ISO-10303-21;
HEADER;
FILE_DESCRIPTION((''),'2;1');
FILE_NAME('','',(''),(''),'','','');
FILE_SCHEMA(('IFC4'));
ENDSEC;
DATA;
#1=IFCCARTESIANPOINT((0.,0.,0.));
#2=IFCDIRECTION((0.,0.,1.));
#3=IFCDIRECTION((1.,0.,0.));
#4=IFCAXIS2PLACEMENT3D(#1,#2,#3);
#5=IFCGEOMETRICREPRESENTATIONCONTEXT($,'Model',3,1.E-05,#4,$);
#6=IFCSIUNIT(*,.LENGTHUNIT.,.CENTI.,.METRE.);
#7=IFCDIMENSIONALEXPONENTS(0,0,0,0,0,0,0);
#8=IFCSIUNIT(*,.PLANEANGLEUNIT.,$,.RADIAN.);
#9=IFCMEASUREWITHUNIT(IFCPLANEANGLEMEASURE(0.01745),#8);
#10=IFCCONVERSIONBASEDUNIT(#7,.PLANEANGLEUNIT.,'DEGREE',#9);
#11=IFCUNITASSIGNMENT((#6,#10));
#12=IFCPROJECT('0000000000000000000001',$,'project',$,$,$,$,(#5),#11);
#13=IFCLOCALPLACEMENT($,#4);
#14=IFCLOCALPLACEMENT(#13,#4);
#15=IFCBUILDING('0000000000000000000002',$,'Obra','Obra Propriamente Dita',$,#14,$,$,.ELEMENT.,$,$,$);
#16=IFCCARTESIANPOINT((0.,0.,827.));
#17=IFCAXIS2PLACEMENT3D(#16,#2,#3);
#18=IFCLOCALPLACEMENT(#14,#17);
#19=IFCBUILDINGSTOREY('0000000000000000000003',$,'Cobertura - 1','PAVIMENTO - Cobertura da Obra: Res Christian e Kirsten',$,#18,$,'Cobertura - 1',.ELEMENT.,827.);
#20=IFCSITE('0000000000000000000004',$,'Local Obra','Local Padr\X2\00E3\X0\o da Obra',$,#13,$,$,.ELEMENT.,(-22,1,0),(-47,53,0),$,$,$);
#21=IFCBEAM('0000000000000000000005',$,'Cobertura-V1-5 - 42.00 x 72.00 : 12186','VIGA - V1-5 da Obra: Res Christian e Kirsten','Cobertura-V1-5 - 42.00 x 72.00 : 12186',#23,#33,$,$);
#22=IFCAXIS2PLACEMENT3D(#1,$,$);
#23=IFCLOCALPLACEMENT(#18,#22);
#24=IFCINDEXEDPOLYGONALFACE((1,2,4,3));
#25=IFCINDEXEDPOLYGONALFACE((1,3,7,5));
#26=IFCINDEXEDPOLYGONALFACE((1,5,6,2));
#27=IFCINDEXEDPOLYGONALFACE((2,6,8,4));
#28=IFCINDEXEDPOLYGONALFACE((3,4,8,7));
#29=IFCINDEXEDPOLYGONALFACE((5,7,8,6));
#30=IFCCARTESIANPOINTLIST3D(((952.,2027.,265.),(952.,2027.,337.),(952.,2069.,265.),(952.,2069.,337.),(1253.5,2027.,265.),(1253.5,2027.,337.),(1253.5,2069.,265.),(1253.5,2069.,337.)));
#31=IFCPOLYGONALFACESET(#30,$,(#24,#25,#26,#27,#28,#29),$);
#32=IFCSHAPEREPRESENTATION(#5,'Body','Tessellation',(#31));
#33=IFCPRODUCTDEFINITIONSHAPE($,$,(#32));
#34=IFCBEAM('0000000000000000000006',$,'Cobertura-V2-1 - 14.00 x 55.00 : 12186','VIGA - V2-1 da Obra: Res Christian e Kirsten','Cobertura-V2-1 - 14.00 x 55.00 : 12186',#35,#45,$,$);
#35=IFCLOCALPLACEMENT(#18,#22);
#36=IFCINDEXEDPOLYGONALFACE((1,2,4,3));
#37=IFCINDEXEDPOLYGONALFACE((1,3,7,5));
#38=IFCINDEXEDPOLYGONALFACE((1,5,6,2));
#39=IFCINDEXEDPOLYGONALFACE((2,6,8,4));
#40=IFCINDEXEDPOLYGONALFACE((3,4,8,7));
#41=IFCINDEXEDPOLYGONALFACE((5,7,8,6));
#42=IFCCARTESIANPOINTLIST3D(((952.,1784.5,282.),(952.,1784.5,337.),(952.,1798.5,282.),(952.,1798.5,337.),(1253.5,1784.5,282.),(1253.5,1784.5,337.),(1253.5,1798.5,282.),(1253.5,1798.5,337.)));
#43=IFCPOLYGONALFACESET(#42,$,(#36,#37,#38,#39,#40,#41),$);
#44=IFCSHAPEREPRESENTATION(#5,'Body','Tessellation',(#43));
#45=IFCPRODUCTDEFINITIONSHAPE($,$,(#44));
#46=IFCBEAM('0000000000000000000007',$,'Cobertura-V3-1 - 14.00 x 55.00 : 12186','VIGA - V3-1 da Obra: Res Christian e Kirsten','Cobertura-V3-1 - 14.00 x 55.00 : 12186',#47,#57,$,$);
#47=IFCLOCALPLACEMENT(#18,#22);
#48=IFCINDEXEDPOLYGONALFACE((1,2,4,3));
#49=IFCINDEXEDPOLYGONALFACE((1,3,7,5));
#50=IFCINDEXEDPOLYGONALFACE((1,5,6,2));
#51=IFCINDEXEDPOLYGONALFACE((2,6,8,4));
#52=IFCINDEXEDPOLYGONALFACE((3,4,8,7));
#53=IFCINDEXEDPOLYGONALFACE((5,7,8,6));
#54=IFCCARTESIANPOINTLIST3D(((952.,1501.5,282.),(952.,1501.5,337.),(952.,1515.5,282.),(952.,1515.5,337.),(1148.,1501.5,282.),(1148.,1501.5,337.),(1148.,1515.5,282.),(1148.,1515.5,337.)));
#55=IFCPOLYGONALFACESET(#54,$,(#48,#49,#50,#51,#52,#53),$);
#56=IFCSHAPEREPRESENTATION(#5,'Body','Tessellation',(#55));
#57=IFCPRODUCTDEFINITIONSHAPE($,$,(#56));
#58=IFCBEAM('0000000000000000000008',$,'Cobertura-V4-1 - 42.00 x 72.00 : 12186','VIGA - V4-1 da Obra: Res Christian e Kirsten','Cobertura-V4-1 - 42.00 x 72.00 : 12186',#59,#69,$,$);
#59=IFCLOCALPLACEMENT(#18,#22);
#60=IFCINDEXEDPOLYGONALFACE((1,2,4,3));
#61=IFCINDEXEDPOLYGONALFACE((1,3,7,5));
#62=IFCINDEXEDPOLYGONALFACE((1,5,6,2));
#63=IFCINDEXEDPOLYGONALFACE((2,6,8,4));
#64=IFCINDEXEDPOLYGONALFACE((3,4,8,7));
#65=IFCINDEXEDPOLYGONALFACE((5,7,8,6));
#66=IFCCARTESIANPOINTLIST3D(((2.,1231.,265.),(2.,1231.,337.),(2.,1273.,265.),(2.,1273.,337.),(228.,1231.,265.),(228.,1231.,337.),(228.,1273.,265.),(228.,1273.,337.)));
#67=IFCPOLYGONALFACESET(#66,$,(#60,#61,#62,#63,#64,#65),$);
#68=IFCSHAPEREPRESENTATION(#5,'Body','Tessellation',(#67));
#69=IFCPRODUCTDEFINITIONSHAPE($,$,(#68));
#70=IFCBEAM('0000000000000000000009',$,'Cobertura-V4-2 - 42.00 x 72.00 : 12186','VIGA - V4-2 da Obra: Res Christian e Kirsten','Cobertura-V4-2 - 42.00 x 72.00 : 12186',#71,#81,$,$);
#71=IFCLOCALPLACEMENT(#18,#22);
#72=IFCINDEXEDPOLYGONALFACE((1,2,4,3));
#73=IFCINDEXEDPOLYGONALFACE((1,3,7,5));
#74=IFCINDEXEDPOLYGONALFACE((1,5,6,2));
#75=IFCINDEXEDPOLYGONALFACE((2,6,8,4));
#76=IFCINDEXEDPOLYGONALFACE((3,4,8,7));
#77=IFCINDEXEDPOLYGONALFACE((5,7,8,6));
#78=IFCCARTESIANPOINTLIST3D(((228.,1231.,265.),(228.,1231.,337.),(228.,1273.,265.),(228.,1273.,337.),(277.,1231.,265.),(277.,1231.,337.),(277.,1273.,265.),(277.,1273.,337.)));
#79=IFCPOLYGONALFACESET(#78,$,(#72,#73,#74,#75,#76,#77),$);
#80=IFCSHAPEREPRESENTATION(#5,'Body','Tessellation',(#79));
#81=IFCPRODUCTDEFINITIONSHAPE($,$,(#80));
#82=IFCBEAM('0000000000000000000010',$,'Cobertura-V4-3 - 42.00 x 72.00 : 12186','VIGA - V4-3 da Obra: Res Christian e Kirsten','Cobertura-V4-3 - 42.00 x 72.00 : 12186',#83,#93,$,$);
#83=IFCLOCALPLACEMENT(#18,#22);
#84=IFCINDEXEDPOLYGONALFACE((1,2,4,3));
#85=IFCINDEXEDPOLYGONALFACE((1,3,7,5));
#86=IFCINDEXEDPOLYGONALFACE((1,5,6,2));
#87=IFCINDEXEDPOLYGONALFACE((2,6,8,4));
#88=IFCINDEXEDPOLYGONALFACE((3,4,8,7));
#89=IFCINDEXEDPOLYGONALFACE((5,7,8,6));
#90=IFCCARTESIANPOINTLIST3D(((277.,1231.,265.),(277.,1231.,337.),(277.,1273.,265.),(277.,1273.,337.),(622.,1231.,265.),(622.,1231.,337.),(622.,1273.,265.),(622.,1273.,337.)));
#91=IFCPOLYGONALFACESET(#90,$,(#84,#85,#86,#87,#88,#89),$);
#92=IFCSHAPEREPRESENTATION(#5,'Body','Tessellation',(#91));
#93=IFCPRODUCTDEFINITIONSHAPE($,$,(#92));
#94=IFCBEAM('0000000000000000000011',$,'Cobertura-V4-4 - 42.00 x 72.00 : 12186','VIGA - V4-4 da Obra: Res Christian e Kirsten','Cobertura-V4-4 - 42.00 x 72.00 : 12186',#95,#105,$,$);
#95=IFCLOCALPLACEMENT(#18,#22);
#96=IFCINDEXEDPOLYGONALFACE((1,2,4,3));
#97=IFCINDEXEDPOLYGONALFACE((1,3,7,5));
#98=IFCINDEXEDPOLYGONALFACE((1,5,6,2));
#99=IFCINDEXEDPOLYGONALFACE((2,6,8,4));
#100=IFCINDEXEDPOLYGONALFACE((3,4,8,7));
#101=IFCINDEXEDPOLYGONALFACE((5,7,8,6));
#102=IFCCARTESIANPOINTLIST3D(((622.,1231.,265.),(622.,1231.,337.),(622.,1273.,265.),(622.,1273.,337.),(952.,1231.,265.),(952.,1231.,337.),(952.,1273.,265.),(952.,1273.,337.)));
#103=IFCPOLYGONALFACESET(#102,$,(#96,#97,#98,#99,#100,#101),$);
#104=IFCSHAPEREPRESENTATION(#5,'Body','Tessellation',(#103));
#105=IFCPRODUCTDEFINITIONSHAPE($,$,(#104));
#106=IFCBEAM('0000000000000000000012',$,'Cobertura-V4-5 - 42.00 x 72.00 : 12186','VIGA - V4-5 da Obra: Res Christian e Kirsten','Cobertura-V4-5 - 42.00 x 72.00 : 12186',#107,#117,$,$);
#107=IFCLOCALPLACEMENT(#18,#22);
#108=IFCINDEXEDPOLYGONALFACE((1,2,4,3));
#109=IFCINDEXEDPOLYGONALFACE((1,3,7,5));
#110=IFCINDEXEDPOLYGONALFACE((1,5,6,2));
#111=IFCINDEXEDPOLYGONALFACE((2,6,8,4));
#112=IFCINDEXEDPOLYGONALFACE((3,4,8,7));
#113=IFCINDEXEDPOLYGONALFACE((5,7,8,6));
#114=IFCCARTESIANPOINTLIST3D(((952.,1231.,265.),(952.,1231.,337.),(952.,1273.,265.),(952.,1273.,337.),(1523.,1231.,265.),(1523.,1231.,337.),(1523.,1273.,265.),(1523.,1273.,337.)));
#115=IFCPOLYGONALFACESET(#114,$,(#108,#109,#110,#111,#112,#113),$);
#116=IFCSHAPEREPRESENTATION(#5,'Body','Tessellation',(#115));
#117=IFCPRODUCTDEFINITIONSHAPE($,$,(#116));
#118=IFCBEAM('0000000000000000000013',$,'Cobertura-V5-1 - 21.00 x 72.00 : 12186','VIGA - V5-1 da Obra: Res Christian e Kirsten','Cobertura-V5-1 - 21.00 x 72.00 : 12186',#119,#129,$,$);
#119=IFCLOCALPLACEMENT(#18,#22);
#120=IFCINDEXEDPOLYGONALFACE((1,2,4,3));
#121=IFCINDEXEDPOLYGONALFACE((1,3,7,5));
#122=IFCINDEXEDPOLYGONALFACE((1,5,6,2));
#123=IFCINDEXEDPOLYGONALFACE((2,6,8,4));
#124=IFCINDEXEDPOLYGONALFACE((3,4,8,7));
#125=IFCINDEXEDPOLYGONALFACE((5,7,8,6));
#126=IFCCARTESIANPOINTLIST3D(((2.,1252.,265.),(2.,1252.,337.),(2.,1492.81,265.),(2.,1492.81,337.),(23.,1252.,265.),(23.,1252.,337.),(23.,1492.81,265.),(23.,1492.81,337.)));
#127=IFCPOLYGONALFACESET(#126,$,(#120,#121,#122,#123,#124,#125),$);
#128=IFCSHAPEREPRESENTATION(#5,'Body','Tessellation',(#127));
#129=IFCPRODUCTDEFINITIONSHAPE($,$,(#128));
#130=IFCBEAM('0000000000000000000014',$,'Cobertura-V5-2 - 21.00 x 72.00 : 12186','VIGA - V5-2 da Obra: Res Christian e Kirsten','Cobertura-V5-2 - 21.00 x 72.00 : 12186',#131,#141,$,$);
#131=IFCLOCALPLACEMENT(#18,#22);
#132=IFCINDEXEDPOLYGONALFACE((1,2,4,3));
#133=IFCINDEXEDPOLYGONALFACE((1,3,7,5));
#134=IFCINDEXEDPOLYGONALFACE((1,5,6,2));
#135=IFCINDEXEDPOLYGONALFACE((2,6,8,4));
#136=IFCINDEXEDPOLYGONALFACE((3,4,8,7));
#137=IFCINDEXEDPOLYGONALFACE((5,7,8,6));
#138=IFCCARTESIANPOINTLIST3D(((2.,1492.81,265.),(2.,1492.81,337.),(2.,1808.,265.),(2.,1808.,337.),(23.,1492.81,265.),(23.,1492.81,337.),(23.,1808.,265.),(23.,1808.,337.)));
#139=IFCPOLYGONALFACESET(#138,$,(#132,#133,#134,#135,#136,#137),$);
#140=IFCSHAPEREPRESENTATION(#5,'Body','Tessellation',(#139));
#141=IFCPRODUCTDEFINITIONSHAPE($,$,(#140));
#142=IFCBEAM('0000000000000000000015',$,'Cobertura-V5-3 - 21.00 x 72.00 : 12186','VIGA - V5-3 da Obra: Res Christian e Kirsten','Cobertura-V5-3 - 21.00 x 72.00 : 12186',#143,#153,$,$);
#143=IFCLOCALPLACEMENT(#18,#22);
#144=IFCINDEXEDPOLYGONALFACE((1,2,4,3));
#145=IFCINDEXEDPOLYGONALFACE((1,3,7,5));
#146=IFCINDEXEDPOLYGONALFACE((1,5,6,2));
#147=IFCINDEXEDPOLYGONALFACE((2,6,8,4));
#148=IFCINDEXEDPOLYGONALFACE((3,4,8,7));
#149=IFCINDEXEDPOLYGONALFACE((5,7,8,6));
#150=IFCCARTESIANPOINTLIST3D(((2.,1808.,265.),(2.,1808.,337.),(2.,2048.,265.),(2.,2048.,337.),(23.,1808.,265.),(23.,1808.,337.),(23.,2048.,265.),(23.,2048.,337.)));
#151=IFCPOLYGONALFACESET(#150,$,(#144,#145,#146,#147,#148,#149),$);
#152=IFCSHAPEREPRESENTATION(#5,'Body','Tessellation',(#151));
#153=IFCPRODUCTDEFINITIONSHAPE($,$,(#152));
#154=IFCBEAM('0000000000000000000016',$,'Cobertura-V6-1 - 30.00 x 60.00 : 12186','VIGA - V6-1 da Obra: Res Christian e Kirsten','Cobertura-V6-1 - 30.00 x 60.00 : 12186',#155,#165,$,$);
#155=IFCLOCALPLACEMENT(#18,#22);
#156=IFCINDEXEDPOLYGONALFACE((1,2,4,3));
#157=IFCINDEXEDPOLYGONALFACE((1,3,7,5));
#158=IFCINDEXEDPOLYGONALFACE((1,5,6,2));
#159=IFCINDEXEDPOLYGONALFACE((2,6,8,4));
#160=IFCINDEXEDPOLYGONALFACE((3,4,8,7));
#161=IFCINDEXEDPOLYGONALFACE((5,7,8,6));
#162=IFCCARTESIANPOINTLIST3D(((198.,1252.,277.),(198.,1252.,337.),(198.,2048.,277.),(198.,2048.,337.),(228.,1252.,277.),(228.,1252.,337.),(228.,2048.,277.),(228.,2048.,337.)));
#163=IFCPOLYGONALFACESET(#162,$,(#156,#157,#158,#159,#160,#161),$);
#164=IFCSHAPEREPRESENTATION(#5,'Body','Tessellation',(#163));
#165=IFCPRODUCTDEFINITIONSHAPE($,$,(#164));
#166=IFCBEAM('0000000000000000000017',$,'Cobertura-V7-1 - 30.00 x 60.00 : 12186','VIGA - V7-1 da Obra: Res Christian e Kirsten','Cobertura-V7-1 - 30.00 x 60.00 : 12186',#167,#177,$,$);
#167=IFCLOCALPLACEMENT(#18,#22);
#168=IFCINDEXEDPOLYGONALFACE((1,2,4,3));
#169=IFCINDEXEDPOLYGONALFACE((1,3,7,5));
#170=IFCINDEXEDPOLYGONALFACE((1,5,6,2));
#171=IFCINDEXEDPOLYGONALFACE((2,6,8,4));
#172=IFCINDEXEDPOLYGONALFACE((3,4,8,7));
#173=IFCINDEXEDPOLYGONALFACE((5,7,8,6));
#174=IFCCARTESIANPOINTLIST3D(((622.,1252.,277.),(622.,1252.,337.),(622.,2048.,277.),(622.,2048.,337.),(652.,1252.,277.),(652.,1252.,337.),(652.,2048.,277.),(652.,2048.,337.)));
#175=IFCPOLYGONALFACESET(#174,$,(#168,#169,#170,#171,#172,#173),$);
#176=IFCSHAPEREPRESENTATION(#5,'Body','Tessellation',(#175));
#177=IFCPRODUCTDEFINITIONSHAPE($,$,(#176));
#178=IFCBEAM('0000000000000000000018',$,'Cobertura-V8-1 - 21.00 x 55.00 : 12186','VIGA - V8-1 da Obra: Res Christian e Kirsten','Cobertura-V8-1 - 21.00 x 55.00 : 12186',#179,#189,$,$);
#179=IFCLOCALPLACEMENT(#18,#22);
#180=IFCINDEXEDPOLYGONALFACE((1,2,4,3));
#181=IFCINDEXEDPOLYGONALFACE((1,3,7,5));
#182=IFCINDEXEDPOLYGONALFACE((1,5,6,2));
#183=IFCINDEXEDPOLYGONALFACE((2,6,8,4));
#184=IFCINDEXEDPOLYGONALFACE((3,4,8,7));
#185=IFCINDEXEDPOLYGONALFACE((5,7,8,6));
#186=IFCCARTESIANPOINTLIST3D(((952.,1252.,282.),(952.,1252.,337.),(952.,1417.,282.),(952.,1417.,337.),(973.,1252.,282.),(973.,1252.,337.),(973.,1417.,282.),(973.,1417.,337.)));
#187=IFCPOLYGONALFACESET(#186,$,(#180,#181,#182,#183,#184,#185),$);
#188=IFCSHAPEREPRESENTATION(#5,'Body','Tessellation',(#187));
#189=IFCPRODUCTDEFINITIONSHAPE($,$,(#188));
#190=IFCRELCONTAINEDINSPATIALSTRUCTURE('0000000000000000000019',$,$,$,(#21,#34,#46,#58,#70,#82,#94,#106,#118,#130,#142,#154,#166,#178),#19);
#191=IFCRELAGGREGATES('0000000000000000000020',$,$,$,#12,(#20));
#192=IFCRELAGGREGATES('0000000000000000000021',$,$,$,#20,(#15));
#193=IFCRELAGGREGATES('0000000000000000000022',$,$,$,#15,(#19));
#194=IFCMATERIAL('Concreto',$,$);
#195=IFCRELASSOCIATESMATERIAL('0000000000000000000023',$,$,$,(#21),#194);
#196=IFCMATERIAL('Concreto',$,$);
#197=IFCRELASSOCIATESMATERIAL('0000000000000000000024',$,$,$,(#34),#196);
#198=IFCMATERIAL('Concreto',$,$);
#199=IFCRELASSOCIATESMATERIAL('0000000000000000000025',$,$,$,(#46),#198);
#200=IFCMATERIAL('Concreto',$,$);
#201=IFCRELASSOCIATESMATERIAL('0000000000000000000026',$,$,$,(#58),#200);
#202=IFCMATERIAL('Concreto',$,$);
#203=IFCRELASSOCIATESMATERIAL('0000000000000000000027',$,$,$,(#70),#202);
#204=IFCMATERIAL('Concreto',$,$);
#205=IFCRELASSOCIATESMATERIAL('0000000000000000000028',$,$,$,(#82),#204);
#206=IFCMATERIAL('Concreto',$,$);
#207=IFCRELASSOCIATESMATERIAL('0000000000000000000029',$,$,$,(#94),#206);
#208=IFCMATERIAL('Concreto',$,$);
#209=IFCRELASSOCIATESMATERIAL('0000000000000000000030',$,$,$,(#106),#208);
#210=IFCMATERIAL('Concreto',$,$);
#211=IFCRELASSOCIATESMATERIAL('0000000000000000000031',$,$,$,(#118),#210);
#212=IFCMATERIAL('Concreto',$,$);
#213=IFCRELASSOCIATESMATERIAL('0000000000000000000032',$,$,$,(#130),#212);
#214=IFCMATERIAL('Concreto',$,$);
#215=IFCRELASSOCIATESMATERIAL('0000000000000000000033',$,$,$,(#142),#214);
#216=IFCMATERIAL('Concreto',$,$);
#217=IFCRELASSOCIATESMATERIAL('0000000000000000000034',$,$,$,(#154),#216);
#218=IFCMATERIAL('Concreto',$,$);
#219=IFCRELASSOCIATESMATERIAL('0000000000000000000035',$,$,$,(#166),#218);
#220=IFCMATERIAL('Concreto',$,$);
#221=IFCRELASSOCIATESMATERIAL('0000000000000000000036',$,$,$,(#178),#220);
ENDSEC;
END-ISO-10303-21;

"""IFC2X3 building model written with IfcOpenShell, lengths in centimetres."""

from ifc_helpers import new_model, entity, si_unit, converted_unit, frame, origin_with_axes, place, context, project, spatial, polyline, outline, extrude, material, element, save


model = new_model("IFC2X3")

# Units and contexts
model_context = context("Model", 3, precision=1e-05, world=origin_with_axes())
ifc_project = project(units=[si_unit("LENGTHUNIT", "METRE", prefix="CENTI"), converted_unit("PLANEANGLEUNIT", "DEGREE", entity("IfcPlaneAngleMeasure", 0.01745), si_unit("PLANEANGLEUNIT", "RADIAN"), dimensions=[0, 0, 0, 0, 0, 0, 0])], contexts=[model_context])

# Site, building, storey
site_placement = place(None, origin_with_axes())
site = spatial("IfcSite", under=ifc_project, at=site_placement, Name="Local Obra", Description="Local Padrão da Obra", CompositionType="ELEMENT", RefLatitude=(-22, 1, 0), RefLongitude=(-47, 53, 0))
building_placement = place(site_placement, origin_with_axes())
building = spatial("IfcBuilding", under=site, at=building_placement, Name="Obra", Description="Obra Propriamente Dita", CompositionType="ELEMENT")
storey_placement = place(building_placement, frame((0.0, 0.0, 827.0), z_axis=(0.0, 0.0, 1.0), x_axis=(1.0, 0.0, 0.0)))
storey = spatial("IfcBuildingStorey", under=building, at=storey_placement, Name="Cobertura - 1", Description="PAVIMENTO - Cobertura da Obra: Res Christian e Kirsten", LongName="Cobertura - 1", CompositionType="ELEMENT", Elevation=827.0)

# Beams
ifc_material_1 = material(Name="Concreto")
beam_1_placement = place(storey_placement, frame((952.0, 2048.0, 337.0), z_axis=(1.0, 0.0, 0.0), x_axis=(0.0, -1.0, 0.0)))
element("IfcBeam", 1, at=beam_1_placement, inside=storey, material=ifc_material_1, Name="Cobertura-V1-5 - 42.00 x 72.00 : 12186", Description="VIGA - V1-5 da Obra: Res Christian e Kirsten", ObjectType="Cobertura-V1-5 - 42.00 x 72.00 : 12186", context=model_context, shape_type="SweptSolid", body=[
    extrude(outline(polyline([(-21.0, 0.0), (21.0, 0.0), (21.0, 72.0), (-21.0, 72.0), (-21.0, 0.0)])), origin_with_axes(), (0.0, 0.0, 1.0), 301.5),
])
ifc_material_2 = material(Name="Concreto")
beam_2_placement = place(storey_placement, frame((952.0, 1791.5, 337.0), z_axis=(1.0, 0.0, 0.0), x_axis=(0.0, -1.0, 0.0)))
element("IfcBeam", 2, at=beam_2_placement, inside=storey, material=ifc_material_2, Name="Cobertura-V2-1 - 14.00 x 55.00 : 12186", Description="VIGA - V2-1 da Obra: Res Christian e Kirsten", ObjectType="Cobertura-V2-1 - 14.00 x 55.00 : 12186", context=model_context, shape_type="SweptSolid", body=[
    extrude(outline(polyline([(-7.0, 0.0), (7.0, 0.0), (7.0, 55.0), (-7.0, 55.0), (-7.0, 0.0)])), origin_with_axes(), (0.0, 0.0, 1.0), 301.5),
])
ifc_material_3 = material(Name="Concreto")
beam_3_placement = place(storey_placement, frame((952.0, 1508.5, 337.0), z_axis=(1.0, 0.0, 0.0), x_axis=(0.0, -1.0, 0.0)))
element("IfcBeam", 3, at=beam_3_placement, inside=storey, material=ifc_material_3, Name="Cobertura-V3-1 - 14.00 x 55.00 : 12186", Description="VIGA - V3-1 da Obra: Res Christian e Kirsten", ObjectType="Cobertura-V3-1 - 14.00 x 55.00 : 12186", context=model_context, shape_type="SweptSolid", body=[
    extrude(outline(polyline([(-7.0, 0.0), (7.0, 0.0), (7.0, 55.0), (-7.0, 55.0), (-7.0, 0.0)])), origin_with_axes(), (0.0, 0.0, 1.0), 196.0),
])
ifc_material_4 = material(Name="Concreto")
beam_4_placement = place(storey_placement, frame((2.0, 1252.0, 337.0), z_axis=(1.0, 0.0, 0.0), x_axis=(0.0, -1.0, 0.0)))
element("IfcBeam", 4, at=beam_4_placement, inside=storey, material=ifc_material_4, Name="Cobertura-V4-1 - 42.00 x 72.00 : 12186", Description="VIGA - V4-1 da Obra: Res Christian e Kirsten", ObjectType="Cobertura-V4-1 - 42.00 x 72.00 : 12186", context=model_context, shape_type="SweptSolid", body=[
    extrude(outline(polyline([(-21.0, 0.0), (21.0, 0.0), (21.0, 72.0), (-21.0, 72.0), (-21.0, 0.0)])), origin_with_axes(), (0.0, 0.0, 1.0), 226.0),
])
ifc_material_5 = material(Name="Concreto")
beam_5_placement = place(storey_placement, frame((228.0, 1252.0, 337.0), z_axis=(1.0, 0.0, 0.0), x_axis=(0.0, -1.0, 0.0)))
element("IfcBeam", 5, at=beam_5_placement, inside=storey, material=ifc_material_5, Name="Cobertura-V4-2 - 42.00 x 72.00 : 12186", Description="VIGA - V4-2 da Obra: Res Christian e Kirsten", ObjectType="Cobertura-V4-2 - 42.00 x 72.00 : 12186", context=model_context, shape_type="SweptSolid", body=[
    extrude(outline(polyline([(-21.0, 0.0), (21.0, 0.0), (21.0, 72.0), (-21.0, 72.0), (-21.0, 0.0)])), origin_with_axes(), (0.0, 0.0, 1.0), 49.0),
])
ifc_material_6 = material(Name="Concreto")
beam_6_placement = place(storey_placement, frame((277.0, 1252.0, 337.0), z_axis=(1.0, 0.0, 0.0), x_axis=(0.0, -1.0, 0.0)))
element("IfcBeam", 6, at=beam_6_placement, inside=storey, material=ifc_material_6, Name="Cobertura-V4-3 - 42.00 x 72.00 : 12186", Description="VIGA - V4-3 da Obra: Res Christian e Kirsten", ObjectType="Cobertura-V4-3 - 42.00 x 72.00 : 12186", context=model_context, shape_type="SweptSolid", body=[
    extrude(outline(polyline([(-21.0, 0.0), (21.0, 0.0), (21.0, 72.0), (-21.0, 72.0), (-21.0, 0.0)])), origin_with_axes(), (0.0, 0.0, 1.0), 345.0),
])
ifc_material_7 = material(Name="Concreto")
beam_7_placement = place(storey_placement, frame((622.0, 1252.0, 337.0), z_axis=(1.0, 0.0, 0.0), x_axis=(0.0, -1.0, 0.0)))
element("IfcBeam", 7, at=beam_7_placement, inside=storey, material=ifc_material_7, Name="Cobertura-V4-4 - 42.00 x 72.00 : 12186", Description="VIGA - V4-4 da Obra: Res Christian e Kirsten", ObjectType="Cobertura-V4-4 - 42.00 x 72.00 : 12186", context=model_context, shape_type="SweptSolid", body=[
    extrude(outline(polyline([(-21.0, 0.0), (21.0, 0.0), (21.0, 72.0), (-21.0, 72.0), (-21.0, 0.0)])), origin_with_axes(), (0.0, 0.0, 1.0), 330.0),
])
ifc_material_8 = material(Name="Concreto")
beam_8_placement = place(storey_placement, frame((952.0, 1252.0, 337.0), z_axis=(1.0, 0.0, 0.0), x_axis=(0.0, -1.0, 0.0)))
element("IfcBeam", 8, at=beam_8_placement, inside=storey, material=ifc_material_8, Name="Cobertura-V4-5 - 42.00 x 72.00 : 12186", Description="VIGA - V4-5 da Obra: Res Christian e Kirsten", ObjectType="Cobertura-V4-5 - 42.00 x 72.00 : 12186", context=model_context, shape_type="SweptSolid", body=[
    extrude(outline(polyline([(-21.0, 0.0), (21.0, 0.0), (21.0, 72.0), (-21.0, 72.0), (-21.0, 0.0)])), origin_with_axes(), (0.0, 0.0, 1.0), 571.0),
])
ifc_material_9 = material(Name="Concreto")
beam_9_placement = place(storey_placement, frame((2.0, 1252.0, 337.0), z_axis=(-0.000002, 1.0, 0.0), x_axis=(1.0, 0.000002, 0.0)))
element("IfcBeam", 9, at=beam_9_placement, inside=storey, material=ifc_material_9, Name="Cobertura-V5-1 - 21.00 x 72.00 : 12186", Description="VIGA - V5-1 da Obra: Res Christian e Kirsten", ObjectType="Cobertura-V5-1 - 21.00 x 72.00 : 12186", context=model_context, shape_type="SweptSolid", body=[
    extrude(outline(polyline([(0.0, 0.0), (21.0, 0.0), (21.0, 72.0), (0.0, 72.0), (0.0, 0.0)])), origin_with_axes(), (0.0, 0.0, 1.0), 240.81),
])
ifc_material_10 = material(Name="Concreto")
beam_10_placement = place(storey_placement, frame((2.0, 1492.81, 337.0), z_axis=(0.0, 1.0, 0.0), x_axis=(1.0, 0.0, 0.0)))
element("IfcBeam", 10, at=beam_10_placement, inside=storey, material=ifc_material_10, Name="Cobertura-V5-2 - 21.00 x 72.00 : 12186", Description="VIGA - V5-2 da Obra: Res Christian e Kirsten", ObjectType="Cobertura-V5-2 - 21.00 x 72.00 : 12186", context=model_context, shape_type="SweptSolid", body=[
    extrude(outline(polyline([(0.0, 0.0), (21.0, 0.0), (21.0, 72.0), (0.0, 72.0), (0.0, 0.0)])), origin_with_axes(), (0.0, 0.0, 1.0), 315.19),
])
ifc_material_11 = material(Name="Concreto")
beam_11_placement = place(storey_placement, frame((2.0, 1808.0, 337.0), z_axis=(0.000002, 1.0, 0.0), x_axis=(1.0, -0.000002, 0.0)))
element("IfcBeam", 11, at=beam_11_placement, inside=storey, material=ifc_material_11, Name="Cobertura-V5-3 - 21.00 x 72.00 : 12186", Description="VIGA - V5-3 da Obra: Res Christian e Kirsten", ObjectType="Cobertura-V5-3 - 21.00 x 72.00 : 12186", context=model_context, shape_type="SweptSolid", body=[
    extrude(outline(polyline([(0.0, 0.0), (21.0, 0.0), (21.0, 72.0), (0.0, 72.0), (0.0, 0.0)])), origin_with_axes(), (0.0, 0.0, 1.0), 240.0),
])
ifc_material_12 = material(Name="Concreto")
beam_12_placement = place(storey_placement, frame((228.0, 1252.0, 337.0), z_axis=(0.0, 1.0, 0.0), x_axis=(1.0, 0.0, 0.0)))
element("IfcBeam", 12, at=beam_12_placement, inside=storey, material=ifc_material_12, Name="Cobertura-V6-1 - 30.00 x 60.00 : 12186", Description="VIGA - V6-1 da Obra: Res Christian e Kirsten", ObjectType="Cobertura-V6-1 - 30.00 x 60.00 : 12186", context=model_context, shape_type="SweptSolid", body=[
    extrude(outline(polyline([(-30.0, 0.0), (0.0, 0.0), (0.0, 60.0), (-30.0, 60.0), (-30.0, 0.0)])), origin_with_axes(), (0.0, 0.0, 1.0), 796.0),
])
ifc_material_13 = material(Name="Concreto")
beam_13_placement = place(storey_placement, frame((622.0, 1252.0, 337.0), z_axis=(0.0, 1.0, 0.0), x_axis=(1.0, 0.0, 0.0)))
element("IfcBeam", 13, at=beam_13_placement, inside=storey, material=ifc_material_13, Name="Cobertura-V7-1 - 30.00 x 60.00 : 12186", Description="VIGA - V7-1 da Obra: Res Christian e Kirsten", ObjectType="Cobertura-V7-1 - 30.00 x 60.00 : 12186", context=model_context, shape_type="SweptSolid", body=[
    extrude(outline(polyline([(0.0, 0.0), (30.0, 0.0), (30.0, 60.0), (0.0, 60.0), (0.0, 0.0)])), origin_with_axes(), (0.0, 0.0, 1.0), 796.0),
])
ifc_material_14 = material(Name="Concreto")
beam_14_placement = place(storey_placement, frame((952.0, 1252.0, 337.0), z_axis=(0.0, 1.0, 0.0), x_axis=(1.0, 0.0, 0.0)))
element("IfcBeam", 14, at=beam_14_placement, inside=storey, material=ifc_material_14, Name="Cobertura-V8-1 - 21.00 x 55.00 : 12186", Description="VIGA - V8-1 da Obra: Res Christian e Kirsten", ObjectType="Cobertura-V8-1 - 21.00 x 55.00 : 12186", context=model_context, shape_type="SweptSolid", body=[
    extrude(outline(polyline([(0.0, 0.0), (21.0, 0.0), (21.0, 55.0), (0.0, 55.0), (0.0, 0.0)])), origin_with_axes(), (0.0, 0.0, 1.0), 165.0),
])

save(model, "model.ifc")
